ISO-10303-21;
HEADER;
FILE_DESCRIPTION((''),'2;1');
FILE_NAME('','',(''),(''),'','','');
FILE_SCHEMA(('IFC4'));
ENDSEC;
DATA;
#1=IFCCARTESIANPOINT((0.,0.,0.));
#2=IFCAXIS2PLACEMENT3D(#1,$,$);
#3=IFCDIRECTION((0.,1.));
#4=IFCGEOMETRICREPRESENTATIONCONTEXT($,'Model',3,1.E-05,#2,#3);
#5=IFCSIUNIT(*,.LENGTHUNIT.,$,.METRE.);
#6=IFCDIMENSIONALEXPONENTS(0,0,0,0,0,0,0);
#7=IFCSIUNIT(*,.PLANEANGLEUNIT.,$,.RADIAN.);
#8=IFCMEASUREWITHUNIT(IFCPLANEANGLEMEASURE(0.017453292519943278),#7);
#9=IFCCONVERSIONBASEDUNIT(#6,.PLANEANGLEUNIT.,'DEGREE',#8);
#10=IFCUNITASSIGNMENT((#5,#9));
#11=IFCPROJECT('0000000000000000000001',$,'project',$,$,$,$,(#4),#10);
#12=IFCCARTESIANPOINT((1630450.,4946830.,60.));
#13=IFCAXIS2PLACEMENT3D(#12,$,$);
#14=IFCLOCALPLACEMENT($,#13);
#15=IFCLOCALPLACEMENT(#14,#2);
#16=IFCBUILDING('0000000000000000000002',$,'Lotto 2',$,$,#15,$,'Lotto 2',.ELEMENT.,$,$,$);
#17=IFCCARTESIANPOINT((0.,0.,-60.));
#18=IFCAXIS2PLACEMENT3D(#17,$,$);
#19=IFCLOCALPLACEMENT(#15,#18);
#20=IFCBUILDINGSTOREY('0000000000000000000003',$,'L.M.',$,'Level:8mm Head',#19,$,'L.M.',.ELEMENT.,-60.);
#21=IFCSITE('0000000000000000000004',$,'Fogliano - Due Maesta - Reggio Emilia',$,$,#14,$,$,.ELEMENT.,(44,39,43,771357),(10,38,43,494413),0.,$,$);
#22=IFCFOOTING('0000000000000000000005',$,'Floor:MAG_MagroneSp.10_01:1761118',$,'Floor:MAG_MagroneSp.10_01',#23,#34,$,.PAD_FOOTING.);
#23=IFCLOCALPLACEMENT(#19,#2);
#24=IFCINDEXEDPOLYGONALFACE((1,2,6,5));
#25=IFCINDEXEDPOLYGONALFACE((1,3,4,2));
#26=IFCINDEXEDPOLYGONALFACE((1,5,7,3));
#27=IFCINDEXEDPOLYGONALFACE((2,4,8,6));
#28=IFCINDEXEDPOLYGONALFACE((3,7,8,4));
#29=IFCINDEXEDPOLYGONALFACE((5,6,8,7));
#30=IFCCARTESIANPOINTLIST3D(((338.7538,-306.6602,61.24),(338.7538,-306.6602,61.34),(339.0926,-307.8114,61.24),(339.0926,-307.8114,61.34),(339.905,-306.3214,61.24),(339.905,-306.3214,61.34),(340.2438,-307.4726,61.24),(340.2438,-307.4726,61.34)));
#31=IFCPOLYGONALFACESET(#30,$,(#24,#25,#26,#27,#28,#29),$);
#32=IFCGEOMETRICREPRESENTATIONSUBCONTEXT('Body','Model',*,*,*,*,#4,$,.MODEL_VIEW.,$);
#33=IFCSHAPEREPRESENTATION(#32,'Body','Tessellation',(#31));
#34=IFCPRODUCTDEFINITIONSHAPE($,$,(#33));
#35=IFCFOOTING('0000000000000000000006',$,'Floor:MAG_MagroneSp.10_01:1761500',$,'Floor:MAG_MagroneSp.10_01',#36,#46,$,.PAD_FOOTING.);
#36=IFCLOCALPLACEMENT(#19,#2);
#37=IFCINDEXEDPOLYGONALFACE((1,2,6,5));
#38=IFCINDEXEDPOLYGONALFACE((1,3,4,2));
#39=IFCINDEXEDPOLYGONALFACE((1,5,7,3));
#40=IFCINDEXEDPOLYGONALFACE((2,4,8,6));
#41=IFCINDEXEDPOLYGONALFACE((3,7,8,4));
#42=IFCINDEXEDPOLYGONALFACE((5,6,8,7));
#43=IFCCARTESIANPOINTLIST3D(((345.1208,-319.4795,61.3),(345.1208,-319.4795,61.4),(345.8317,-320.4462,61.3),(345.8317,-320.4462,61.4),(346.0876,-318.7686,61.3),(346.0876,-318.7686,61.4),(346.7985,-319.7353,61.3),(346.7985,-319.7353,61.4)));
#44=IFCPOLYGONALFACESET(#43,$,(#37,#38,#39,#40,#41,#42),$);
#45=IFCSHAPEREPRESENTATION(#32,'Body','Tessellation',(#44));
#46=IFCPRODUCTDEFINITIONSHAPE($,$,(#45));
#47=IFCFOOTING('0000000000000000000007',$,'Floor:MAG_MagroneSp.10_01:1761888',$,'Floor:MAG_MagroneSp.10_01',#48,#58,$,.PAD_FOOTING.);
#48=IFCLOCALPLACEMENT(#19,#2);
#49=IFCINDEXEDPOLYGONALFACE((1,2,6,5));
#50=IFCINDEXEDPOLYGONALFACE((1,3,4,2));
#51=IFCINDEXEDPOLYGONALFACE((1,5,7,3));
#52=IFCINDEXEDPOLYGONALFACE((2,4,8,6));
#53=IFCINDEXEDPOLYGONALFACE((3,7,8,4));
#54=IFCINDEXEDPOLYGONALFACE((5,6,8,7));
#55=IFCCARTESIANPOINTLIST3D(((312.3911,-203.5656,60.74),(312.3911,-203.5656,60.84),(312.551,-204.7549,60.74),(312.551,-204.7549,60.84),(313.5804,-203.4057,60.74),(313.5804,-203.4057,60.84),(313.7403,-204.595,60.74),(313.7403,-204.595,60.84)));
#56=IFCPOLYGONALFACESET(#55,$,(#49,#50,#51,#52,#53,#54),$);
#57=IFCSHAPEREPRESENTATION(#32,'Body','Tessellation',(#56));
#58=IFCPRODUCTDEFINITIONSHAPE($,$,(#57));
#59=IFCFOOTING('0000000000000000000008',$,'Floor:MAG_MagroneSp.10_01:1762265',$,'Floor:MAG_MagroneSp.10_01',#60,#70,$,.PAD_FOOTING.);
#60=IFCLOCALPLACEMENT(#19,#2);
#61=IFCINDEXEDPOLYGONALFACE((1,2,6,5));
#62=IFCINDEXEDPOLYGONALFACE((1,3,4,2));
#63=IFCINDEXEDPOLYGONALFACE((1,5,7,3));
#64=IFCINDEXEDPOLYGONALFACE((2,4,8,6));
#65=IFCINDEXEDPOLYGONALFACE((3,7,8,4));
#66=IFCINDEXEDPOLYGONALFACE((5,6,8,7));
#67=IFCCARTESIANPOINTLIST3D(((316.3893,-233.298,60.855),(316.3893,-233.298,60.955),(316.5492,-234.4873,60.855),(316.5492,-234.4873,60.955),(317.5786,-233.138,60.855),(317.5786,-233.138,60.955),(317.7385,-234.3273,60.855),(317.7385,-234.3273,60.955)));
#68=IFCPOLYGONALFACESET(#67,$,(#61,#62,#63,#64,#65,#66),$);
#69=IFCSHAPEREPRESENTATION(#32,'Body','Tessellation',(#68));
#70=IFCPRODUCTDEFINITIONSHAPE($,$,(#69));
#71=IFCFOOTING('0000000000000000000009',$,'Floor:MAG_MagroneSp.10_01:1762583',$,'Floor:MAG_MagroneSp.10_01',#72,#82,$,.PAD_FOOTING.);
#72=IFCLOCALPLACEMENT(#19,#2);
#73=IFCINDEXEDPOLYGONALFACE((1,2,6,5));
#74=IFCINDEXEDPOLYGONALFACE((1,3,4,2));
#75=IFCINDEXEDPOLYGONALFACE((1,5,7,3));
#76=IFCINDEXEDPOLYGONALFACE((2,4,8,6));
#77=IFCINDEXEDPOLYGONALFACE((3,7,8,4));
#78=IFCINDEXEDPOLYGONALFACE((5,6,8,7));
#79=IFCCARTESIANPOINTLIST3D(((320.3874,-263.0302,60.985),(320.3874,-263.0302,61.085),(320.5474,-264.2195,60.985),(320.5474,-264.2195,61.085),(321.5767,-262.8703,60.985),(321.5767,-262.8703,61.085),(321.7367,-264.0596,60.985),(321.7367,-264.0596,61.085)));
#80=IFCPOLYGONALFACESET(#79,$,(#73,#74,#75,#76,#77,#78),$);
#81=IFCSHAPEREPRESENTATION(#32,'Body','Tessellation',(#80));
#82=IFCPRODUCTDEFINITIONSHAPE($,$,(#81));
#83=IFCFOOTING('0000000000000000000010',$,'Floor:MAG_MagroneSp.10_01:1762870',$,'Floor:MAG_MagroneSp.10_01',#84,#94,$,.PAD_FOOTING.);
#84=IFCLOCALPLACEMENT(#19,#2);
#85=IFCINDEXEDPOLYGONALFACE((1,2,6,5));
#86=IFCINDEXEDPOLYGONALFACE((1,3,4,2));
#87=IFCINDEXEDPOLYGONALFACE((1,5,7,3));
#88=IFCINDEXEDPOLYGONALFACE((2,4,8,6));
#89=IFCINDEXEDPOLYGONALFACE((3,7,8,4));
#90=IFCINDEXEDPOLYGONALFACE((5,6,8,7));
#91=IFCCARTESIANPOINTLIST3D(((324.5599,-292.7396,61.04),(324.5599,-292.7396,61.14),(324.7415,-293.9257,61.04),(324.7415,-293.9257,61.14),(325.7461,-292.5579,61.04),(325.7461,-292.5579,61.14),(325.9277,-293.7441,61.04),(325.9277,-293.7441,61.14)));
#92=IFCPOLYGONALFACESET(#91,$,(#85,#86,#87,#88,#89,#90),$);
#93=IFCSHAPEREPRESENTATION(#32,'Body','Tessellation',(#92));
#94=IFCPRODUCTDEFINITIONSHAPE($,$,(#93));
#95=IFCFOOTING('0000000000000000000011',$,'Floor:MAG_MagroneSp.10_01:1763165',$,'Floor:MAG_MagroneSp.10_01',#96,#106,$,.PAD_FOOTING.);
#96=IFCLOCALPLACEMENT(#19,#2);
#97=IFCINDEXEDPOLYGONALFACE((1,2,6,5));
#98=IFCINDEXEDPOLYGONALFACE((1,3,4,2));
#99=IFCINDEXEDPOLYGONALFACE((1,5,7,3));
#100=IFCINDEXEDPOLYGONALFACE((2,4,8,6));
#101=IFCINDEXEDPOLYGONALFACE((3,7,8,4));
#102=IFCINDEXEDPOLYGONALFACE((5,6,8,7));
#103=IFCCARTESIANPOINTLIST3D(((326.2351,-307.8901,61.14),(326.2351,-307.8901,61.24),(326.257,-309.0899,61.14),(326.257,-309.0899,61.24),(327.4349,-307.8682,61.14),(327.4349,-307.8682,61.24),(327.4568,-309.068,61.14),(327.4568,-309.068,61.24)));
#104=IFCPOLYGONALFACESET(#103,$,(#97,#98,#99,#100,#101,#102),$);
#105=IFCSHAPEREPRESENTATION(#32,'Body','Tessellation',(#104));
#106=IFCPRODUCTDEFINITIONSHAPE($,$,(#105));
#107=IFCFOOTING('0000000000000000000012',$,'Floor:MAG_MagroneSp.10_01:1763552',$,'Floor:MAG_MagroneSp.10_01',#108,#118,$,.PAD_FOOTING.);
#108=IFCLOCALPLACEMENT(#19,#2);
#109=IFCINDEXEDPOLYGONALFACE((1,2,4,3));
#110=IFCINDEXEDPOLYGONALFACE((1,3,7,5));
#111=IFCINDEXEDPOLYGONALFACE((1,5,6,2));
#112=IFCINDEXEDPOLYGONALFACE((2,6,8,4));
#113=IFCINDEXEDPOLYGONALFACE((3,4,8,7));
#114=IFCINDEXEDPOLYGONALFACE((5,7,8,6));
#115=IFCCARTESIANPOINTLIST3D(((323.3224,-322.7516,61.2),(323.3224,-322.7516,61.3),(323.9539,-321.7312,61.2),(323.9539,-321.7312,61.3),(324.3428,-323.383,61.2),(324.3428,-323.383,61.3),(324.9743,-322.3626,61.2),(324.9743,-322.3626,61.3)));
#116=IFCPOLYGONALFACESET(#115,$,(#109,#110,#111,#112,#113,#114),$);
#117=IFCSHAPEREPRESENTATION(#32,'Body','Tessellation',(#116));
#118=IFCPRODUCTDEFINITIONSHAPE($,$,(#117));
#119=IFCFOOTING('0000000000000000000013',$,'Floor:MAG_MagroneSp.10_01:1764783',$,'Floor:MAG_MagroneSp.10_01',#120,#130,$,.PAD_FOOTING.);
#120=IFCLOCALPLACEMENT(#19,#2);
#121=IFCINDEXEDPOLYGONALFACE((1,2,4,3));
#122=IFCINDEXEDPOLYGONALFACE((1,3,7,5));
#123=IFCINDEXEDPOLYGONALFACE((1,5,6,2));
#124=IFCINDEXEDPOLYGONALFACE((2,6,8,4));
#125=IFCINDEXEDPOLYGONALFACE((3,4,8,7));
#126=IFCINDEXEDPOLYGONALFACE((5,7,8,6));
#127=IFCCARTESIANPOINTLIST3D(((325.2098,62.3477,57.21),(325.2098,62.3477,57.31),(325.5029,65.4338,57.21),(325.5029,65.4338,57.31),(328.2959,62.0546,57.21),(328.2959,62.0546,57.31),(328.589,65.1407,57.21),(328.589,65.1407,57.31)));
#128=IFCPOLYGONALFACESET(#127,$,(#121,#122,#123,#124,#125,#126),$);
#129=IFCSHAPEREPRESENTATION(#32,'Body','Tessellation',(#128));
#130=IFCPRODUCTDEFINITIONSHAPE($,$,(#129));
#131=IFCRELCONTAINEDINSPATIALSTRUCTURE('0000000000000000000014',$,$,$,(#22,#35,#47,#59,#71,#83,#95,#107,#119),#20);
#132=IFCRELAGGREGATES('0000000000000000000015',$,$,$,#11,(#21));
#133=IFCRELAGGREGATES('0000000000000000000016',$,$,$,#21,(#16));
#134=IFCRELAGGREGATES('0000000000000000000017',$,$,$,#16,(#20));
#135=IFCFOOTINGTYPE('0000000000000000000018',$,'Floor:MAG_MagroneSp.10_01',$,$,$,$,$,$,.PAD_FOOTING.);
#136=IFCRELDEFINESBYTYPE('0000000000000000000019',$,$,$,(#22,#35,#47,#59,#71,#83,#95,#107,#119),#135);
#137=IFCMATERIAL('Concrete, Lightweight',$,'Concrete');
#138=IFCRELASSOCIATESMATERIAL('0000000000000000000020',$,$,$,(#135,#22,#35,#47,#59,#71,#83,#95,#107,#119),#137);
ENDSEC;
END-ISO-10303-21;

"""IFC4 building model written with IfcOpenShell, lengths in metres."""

from ifc_helpers import new_model, entity, si_unit, converted_unit, direction, frame, origin, place, context, subcontext, project, spatial, indexed_curve, outline, extrude, material, type_object, element, save


model = new_model("IFC4")

# Units and contexts
model_context = context("Model", 3, precision=1e-05, world=origin(), true_north=direction((0.0, 1.0)))
body_context = subcontext(model_context, "Body", "Model", "MODEL_VIEW")
ifc_project = project(units=[si_unit("LENGTHUNIT", "METRE"), converted_unit("PLANEANGLEUNIT", "DEGREE", entity("IfcPlaneAngleMeasure", 0.017453292519943278), si_unit("PLANEANGLEUNIT", "RADIAN"), dimensions=[0, 0, 0, 0, 0, 0, 0])], contexts=[model_context])

# Site, building, storey
site_placement = place(None, frame((1630450.0, 4946830.0, 60.0)))
site = spatial("IfcSite", under=ifc_project, at=site_placement, Name="Fogliano - Due Maesta - Reggio Emilia", CompositionType="ELEMENT", RefLatitude=(44, 39, 43, 771357), RefLongitude=(10, 38, 43, 494413), RefElevation=0.0)
building_placement = place(site_placement, origin())
building = spatial("IfcBuilding", under=site, at=building_placement, Name="Lotto 2", LongName="Lotto 2", CompositionType="ELEMENT")
storey_placement = place(building_placement, frame((0.0, 0.0, -60.0)))
storey = spatial("IfcBuildingStorey", under=building, at=storey_placement, Name="L.M.", ObjectType="Level:8mm Head", LongName="L.M.", CompositionType="ELEMENT", Elevation=-60.0)

# Footings
ifc_material = material(Name="Concrete, Lightweight", Category="Concrete")
footing_type = type_object("IfcFootingType", Name="Floor:MAG_MagroneSp.10_01", PredefinedType="PAD_FOOTING", material=ifc_material)
footing_1_placement = place(storey_placement, origin())
element("IfcFooting", 1, at=footing_1_placement, inside=storey, type_object=footing_type, material=ifc_material, Name="Floor:MAG_MagroneSp.10_01:1761118", ObjectType="Floor:MAG_MagroneSp.10_01", PredefinedType="PAD_FOOTING", context=body_context, shape_type="SweptSolid", body=[
    extrude(outline(indexed_curve([(-0.6, -0.6), (0.6, -0.6), (0.6, 0.6), (-0.6, 0.6), (-0.6, -0.6)], self_intersect=False)), frame((339.4988, -307.0664, 61.34), z_axis=(0.0, 0.0, -1.0), x_axis=(0.282333, -0.959316, 0.0)), (0.0, 0.0, 1.0), 0.1),
])
footing_2_placement = place(storey_placement, origin())
element("IfcFooting", 2, at=footing_2_placement, inside=storey, type_object=footing_type, material=ifc_material, Name="Floor:MAG_MagroneSp.10_01:1761500", ObjectType="Floor:MAG_MagroneSp.10_01", PredefinedType="PAD_FOOTING", context=body_context, shape_type="SweptSolid", body=[
    extrude(outline(indexed_curve([(-0.6, -0.6), (0.6, -0.6), (0.6, 0.6), (-0.6, 0.6), (-0.6, -0.6)], self_intersect=False)), frame((345.9596, -319.6074, 61.4), z_axis=(0.0, 0.0, -1.0), x_axis=(0.592415, -0.805633, 0.0)), (0.0, 0.0, 1.0), 0.1),
])
footing_3_placement = place(storey_placement, origin())
element("IfcFooting", 3, at=footing_3_placement, inside=storey, type_object=footing_type, material=ifc_material, Name="Floor:MAG_MagroneSp.10_01:1761888", ObjectType="Floor:MAG_MagroneSp.10_01", PredefinedType="PAD_FOOTING", context=body_context, shape_type="SweptSolid", body=[
    extrude(outline(indexed_curve([(-0.6, -0.6), (0.6, -0.6), (0.6, 0.6), (-0.6, 0.6), (-0.6, -0.6)], self_intersect=False)), frame((313.0657, -204.0803, 60.84), z_axis=(0.0, 0.0, -1.0), x_axis=(0.133272, -0.991079, 0.0)), (0.0, 0.0, 1.0), 0.1),
])
footing_4_placement = place(storey_placement, origin())
element("IfcFooting", 4, at=footing_4_placement, inside=storey, type_object=footing_type, material=ifc_material, Name="Floor:MAG_MagroneSp.10_01:1762265", ObjectType="Floor:MAG_MagroneSp.10_01", PredefinedType="PAD_FOOTING", context=body_context, shape_type="SweptSolid", body=[
    extrude(outline(indexed_curve([(-0.6, -0.6), (0.6, -0.6), (0.6, 0.6), (-0.6, 0.6), (-0.6, -0.6)], self_intersect=False)), frame((317.0639, -233.8127, 60.955), z_axis=(0.0, 0.0, -1.0), x_axis=(0.133272, -0.991079, 0.0)), (0.0, 0.0, 1.0), 0.1),
])
footing_5_placement = place(storey_placement, origin())
element("IfcFooting", 5, at=footing_5_placement, inside=storey, type_object=footing_type, material=ifc_material, Name="Floor:MAG_MagroneSp.10_01:1762583", ObjectType="Floor:MAG_MagroneSp.10_01", PredefinedType="PAD_FOOTING", context=body_context, shape_type="SweptSolid", body=[
    extrude(outline(indexed_curve([(-0.6, -0.6), (0.6, -0.6), (0.6, 0.6), (-0.6, 0.6), (-0.6, -0.6)], self_intersect=False)), frame((321.062, -263.5449, 61.085), z_axis=(0.0, 0.0, -1.0), x_axis=(0.133272, -0.991079, 0.0)), (0.0, 0.0, 1.0), 0.1),
])
footing_6_placement = place(storey_placement, origin())
element("IfcFooting", 6, at=footing_6_placement, inside=storey, type_object=footing_type, material=ifc_material, Name="Floor:MAG_MagroneSp.10_01:1762870", ObjectType="Floor:MAG_MagroneSp.10_01", PredefinedType="PAD_FOOTING", context=body_context, shape_type="SweptSolid", body=[
    extrude(outline(indexed_curve([(-0.6, -0.6), (0.6, -0.6), (0.6, 0.6), (-0.6, 0.6), (-0.6, -0.6)], self_intersect=False)), frame((325.2438, -293.2418, 61.14), z_axis=(0.0, 0.0, -1.0), x_axis=(0.151347, -0.988481, 0.0)), (0.0, 0.0, 1.0), 0.1),
])
footing_7_placement = place(storey_placement, origin())
element("IfcFooting", 7, at=footing_7_placement, inside=storey, type_object=footing_type, material=ifc_material, Name="Floor:MAG_MagroneSp.10_01:1763165", ObjectType="Floor:MAG_MagroneSp.10_01", PredefinedType="PAD_FOOTING", context=body_context, shape_type="SweptSolid", body=[
    extrude(outline(indexed_curve([(-0.6, -0.6), (0.6, -0.6), (0.6, 0.6), (-0.6, 0.6), (-0.6, -0.6)], self_intersect=False)), frame((326.8459, -308.479, 61.24), z_axis=(0.0, 0.0, -1.0), x_axis=(0.018231, -0.999834, 0.0)), (0.0, 0.0, 1.0), 0.1),
])
footing_8_placement = place(storey_placement, origin())
element("IfcFooting", 8, at=footing_8_placement, inside=storey, type_object=footing_type, material=ifc_material, Name="Floor:MAG_MagroneSp.10_01:1763552", ObjectType="Floor:MAG_MagroneSp.10_01", PredefinedType="PAD_FOOTING", context=body_context, shape_type="SweptSolid", body=[
    extrude(outline(indexed_curve([(-0.6, -0.6), (0.6, -0.6), (0.6, 0.6), (-0.6, 0.6), (-0.6, -0.6)], self_intersect=False)), frame((324.1483, -322.5571, 61.3), z_axis=(0.0, 0.0, -1.0), x_axis=(-0.526214, -0.850352, 0.0)), (0.0, 0.0, 1.0), 0.1),
])
footing_9_placement = place(storey_placement, origin())
element("IfcFooting", 9, at=footing_9_placement, inside=storey, type_object=footing_type, material=ifc_material, Name="Floor:MAG_MagroneSp.10_01:1764783", ObjectType="Floor:MAG_MagroneSp.10_01", PredefinedType="PAD_FOOTING", context=body_context, shape_type="SweptSolid", body=[
    extrude(outline(indexed_curve([(-1.55, -1.55), (1.55, -1.55), (1.55, 1.55), (-1.55, 1.55), (-1.55, -1.55)], self_intersect=False)), frame((326.8994, 63.7442, 57.31), z_axis=(0.0, 0.0, -1.0), x_axis=(-0.094555, -0.99552, 0.0)), (0.0, 0.0, 1.0), 0.1),
])

save(model, "model.ifc")
